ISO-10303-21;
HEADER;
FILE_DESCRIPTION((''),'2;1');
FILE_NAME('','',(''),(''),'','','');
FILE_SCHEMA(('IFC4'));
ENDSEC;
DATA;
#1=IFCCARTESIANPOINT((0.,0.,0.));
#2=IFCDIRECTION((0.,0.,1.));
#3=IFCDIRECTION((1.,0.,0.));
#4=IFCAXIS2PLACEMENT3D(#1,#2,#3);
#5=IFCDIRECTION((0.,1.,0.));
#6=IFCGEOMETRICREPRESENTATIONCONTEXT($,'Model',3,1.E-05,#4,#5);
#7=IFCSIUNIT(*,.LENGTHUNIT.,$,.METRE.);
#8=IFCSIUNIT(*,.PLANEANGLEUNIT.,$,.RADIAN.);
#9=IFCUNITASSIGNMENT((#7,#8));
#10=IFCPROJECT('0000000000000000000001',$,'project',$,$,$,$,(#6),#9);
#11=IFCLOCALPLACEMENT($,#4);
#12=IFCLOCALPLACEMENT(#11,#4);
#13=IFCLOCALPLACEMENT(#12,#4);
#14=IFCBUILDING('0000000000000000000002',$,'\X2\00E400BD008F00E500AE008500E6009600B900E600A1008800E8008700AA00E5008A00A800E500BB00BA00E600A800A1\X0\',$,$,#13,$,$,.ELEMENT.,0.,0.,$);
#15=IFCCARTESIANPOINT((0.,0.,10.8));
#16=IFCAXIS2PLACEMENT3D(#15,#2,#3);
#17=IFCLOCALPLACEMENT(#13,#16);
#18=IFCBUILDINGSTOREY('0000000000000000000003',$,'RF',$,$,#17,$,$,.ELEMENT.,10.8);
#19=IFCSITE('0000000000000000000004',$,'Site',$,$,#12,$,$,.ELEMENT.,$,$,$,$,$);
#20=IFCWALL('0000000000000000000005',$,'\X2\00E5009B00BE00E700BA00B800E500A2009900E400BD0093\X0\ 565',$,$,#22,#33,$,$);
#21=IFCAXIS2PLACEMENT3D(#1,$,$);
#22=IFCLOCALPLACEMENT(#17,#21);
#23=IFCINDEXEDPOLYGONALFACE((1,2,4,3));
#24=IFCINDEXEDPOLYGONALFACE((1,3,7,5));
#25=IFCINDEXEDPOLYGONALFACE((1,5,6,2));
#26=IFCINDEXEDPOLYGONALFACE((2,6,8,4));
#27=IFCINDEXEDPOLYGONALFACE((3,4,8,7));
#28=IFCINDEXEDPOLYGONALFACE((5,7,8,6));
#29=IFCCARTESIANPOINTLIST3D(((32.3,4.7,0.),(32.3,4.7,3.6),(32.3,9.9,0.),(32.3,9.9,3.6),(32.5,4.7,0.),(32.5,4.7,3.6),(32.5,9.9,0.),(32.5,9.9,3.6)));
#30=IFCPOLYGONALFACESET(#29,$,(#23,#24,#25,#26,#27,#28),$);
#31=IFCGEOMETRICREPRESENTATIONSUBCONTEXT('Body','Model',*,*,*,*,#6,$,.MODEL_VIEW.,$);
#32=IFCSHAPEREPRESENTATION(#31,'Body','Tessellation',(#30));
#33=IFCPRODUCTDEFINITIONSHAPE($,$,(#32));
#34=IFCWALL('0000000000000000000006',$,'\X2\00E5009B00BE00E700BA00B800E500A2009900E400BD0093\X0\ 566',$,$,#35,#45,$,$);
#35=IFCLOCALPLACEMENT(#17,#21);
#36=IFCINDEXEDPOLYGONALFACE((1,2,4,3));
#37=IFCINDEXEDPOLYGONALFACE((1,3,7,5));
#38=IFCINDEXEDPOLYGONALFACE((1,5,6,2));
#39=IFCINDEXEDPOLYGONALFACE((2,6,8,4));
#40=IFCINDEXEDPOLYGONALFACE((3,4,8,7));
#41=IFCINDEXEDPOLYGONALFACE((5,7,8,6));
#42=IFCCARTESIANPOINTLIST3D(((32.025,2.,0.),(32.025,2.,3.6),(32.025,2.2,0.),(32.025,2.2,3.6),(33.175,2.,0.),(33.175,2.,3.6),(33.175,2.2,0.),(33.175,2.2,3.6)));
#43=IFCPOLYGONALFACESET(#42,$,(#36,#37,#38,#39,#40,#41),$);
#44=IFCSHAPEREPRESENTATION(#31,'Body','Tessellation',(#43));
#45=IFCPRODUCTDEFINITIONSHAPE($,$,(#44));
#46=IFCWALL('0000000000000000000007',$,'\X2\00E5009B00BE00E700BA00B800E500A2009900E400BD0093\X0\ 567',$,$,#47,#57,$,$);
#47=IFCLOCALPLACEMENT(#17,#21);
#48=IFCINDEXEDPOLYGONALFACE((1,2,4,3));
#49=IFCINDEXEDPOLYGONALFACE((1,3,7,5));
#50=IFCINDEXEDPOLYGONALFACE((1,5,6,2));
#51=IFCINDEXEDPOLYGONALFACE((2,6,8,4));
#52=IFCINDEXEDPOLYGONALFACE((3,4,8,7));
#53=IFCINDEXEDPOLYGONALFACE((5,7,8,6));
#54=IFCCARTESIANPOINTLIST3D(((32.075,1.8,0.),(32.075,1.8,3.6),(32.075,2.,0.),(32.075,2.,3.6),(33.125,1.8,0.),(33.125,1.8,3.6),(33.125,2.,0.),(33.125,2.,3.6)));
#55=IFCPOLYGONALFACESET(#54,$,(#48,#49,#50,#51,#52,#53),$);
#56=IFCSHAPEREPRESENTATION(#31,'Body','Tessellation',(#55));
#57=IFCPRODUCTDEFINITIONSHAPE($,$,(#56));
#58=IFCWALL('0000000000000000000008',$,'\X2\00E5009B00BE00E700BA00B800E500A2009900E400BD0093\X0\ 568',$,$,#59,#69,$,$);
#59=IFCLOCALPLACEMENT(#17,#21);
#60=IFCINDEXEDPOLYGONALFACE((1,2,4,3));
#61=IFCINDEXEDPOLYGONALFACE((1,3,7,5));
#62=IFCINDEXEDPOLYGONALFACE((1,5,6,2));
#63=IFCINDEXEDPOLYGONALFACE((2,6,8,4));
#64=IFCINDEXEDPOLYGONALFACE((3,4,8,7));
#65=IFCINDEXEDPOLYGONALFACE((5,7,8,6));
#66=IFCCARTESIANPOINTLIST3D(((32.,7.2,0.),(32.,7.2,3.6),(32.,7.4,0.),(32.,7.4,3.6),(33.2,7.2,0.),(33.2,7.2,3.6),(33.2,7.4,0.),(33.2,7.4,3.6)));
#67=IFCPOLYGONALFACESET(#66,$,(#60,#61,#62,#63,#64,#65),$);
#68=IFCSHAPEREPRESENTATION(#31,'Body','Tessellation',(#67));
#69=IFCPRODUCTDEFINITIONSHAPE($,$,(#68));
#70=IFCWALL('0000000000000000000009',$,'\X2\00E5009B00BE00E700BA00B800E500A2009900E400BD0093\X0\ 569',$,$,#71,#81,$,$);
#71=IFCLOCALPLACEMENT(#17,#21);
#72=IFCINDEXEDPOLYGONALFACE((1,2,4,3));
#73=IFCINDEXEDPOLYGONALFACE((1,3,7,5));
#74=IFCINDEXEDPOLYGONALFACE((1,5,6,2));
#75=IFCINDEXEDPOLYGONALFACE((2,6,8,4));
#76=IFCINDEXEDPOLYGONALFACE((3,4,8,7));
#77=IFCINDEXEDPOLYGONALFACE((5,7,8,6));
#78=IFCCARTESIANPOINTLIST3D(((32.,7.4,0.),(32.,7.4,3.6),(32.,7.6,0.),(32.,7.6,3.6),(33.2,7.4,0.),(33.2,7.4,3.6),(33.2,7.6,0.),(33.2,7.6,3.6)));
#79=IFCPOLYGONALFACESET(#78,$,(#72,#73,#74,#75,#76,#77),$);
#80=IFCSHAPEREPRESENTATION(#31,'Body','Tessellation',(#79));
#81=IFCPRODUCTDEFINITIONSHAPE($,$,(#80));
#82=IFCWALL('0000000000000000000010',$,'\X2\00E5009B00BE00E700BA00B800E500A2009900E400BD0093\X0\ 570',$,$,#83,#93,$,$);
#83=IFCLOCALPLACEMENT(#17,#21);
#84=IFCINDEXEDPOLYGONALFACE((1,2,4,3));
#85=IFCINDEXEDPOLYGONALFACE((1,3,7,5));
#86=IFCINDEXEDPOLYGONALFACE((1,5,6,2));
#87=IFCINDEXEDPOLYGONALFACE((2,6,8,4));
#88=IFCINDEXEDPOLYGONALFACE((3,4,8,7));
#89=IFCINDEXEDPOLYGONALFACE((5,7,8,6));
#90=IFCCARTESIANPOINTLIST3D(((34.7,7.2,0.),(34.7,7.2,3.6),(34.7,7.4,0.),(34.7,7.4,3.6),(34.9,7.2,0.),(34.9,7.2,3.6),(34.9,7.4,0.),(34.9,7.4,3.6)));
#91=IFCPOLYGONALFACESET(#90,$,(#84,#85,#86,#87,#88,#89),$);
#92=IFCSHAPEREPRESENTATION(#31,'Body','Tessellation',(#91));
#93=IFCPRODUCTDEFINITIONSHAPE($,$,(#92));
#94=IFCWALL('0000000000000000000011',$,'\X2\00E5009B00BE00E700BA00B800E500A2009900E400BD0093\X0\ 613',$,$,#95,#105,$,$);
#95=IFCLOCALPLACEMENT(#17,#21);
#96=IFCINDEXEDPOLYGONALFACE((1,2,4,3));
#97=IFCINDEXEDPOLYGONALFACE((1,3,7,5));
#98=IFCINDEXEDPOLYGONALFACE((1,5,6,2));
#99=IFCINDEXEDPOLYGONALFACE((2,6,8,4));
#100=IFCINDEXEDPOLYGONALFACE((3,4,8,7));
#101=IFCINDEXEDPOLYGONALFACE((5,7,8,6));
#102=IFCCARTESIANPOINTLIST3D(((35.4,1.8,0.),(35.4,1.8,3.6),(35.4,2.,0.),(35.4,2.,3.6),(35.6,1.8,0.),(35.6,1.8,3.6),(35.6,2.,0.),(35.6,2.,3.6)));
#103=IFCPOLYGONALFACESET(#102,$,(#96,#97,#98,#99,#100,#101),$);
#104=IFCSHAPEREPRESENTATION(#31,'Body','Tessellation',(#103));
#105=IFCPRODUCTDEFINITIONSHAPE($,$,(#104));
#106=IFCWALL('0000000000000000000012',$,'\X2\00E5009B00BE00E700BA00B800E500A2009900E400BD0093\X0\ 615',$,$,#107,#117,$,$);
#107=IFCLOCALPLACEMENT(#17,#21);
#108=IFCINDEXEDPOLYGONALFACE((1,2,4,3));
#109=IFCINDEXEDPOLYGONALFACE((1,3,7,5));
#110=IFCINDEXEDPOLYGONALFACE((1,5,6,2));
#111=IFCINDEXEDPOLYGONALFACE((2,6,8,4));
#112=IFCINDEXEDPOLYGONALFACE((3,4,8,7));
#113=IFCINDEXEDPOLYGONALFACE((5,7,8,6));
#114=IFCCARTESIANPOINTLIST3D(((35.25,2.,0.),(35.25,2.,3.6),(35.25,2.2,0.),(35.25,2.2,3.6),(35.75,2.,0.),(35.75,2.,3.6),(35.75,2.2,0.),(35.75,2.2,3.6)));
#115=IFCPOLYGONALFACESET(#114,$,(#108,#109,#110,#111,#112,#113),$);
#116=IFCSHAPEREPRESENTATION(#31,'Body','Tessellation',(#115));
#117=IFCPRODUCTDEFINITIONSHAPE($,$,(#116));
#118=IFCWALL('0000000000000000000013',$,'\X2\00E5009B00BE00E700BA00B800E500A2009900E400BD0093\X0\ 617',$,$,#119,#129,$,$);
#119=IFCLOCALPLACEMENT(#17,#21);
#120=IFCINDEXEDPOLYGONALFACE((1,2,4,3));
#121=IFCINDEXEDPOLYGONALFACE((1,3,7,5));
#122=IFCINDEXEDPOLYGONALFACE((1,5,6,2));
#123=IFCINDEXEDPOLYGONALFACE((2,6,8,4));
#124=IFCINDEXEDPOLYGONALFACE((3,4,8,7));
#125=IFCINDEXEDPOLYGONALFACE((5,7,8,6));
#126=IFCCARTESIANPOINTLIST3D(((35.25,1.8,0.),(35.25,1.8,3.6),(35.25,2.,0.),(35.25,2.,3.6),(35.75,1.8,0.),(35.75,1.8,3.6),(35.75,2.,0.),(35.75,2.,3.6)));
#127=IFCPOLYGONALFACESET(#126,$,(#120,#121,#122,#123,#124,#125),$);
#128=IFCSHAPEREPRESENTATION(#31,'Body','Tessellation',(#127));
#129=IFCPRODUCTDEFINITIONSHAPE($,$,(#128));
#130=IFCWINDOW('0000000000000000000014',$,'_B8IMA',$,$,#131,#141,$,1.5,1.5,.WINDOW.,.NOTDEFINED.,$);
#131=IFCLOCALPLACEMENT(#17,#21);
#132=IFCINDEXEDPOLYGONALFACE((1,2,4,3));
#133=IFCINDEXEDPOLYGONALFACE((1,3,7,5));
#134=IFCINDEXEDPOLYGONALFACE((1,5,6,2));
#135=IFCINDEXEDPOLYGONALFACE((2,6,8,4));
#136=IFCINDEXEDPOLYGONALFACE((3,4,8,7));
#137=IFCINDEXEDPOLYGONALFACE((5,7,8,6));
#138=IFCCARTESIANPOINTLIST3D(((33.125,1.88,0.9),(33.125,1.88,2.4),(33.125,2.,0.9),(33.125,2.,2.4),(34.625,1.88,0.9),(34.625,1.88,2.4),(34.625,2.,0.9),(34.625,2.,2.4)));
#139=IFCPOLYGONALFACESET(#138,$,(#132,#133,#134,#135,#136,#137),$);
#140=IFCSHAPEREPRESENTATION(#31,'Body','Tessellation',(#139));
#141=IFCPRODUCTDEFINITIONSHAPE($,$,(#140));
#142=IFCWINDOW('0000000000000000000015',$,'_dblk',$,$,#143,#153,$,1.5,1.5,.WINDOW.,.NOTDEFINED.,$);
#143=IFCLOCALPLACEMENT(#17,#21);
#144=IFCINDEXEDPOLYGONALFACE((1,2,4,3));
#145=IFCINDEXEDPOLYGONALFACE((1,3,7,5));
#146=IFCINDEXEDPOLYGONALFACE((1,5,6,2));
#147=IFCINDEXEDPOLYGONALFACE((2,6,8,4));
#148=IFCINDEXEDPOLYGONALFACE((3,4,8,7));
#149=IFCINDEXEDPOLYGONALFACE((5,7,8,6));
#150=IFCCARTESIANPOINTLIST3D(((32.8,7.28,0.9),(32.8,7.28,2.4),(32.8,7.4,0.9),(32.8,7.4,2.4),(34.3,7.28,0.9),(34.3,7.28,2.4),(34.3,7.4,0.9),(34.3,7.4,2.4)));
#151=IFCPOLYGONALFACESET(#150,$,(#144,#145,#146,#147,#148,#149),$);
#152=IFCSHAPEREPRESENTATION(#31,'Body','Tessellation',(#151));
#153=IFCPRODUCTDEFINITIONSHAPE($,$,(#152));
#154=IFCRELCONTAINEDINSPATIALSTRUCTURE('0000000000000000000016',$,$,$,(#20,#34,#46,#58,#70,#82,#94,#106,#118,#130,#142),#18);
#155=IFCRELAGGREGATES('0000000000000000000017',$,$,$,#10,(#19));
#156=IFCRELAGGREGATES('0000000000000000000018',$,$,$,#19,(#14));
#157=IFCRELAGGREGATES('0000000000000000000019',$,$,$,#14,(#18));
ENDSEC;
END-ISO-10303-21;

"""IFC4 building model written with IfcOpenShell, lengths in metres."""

from ifc_helpers import new_model, si_unit, direction, frame, frame_2d, origin_with_axes, place, context, subcontext, project, spatial, rectangle, extrude, element, save


model = new_model("IFC4")

# Units and contexts
model_context = context("Model", 3, precision=1e-05, world=origin_with_axes(), true_north=direction((0.0, 1.0, 0.0)))
body_context = subcontext(model_context, "Body", "Model", "MODEL_VIEW")
ifc_project = project(units=[si_unit("LENGTHUNIT", "METRE"), si_unit("PLANEANGLEUNIT", "RADIAN")], contexts=[model_context])

# Site, building, storey
placement = place(None, origin_with_axes())
site_placement = place(placement, origin_with_axes())
site = spatial("IfcSite", under=ifc_project, at=site_placement, Name="Site", CompositionType="ELEMENT")
building_placement = place(site_placement, origin_with_axes())
building = spatial("IfcBuilding", under=site, at=building_placement, Name="ä½\u008få®\u0085æ\u0096¹æ¡\u0088è\u0087ªå\u008a¨å»ºæ¨¡", CompositionType="ELEMENT", ElevationOfRefHeight=0.0, ElevationOfTerrain=0.0)
storey_placement = place(building_placement, frame((0.0, 0.0, 10.8), z_axis=(0.0, 0.0, 1.0), x_axis=(1.0, 0.0, 0.0)))
storey = spatial("IfcBuildingStorey", under=building, at=storey_placement, Name="RF", CompositionType="ELEMENT", Elevation=10.8)

# Walls
for number, where, z_axis, x_axis, name in (
    (1, (32.4, 7.3, 0.0), (0.0, 0.0, 1.0), (0.0, -1.0, 0.0), "å\u009b¾çº¸å¢\u0099ä½\u0093 565"),
):
    element("IfcWall", number, at=place(storey_placement, frame(where, z_axis=z_axis, x_axis=x_axis)), inside=storey, Name=name, context=body_context, shape_type="SweptSolid", body=[
        extrude(rectangle(XDim=5.2, YDim=0.2, at=frame_2d((0.0, 0.0), x_axis=(1.0, 0.0, 0.0))), frame((0.0, 0.0, 0.0), z_axis=(0.0, 0.0, 1.0)), (0.0, 0.0, 1.0), 3.6),
    ])
wall_1_placement = place(storey_placement, frame((32.6, 2.1, 0.0), z_axis=(0.0, 0.0, 1.0), x_axis=(1.0, 0.0, 0.0)))
element("IfcWall", 2, at=wall_1_placement, inside=storey, Name="å\u009b¾çº¸å¢\u0099ä½\u0093 566", context=body_context, shape_type="SweptSolid", body=[
    extrude(rectangle(XDim=1.15, YDim=0.2, at=frame_2d((0.0, 0.0), x_axis=(1.0, 0.0, 0.0))), frame((0.0, 0.0, 0.0), z_axis=(0.0, 0.0, 1.0)), (0.0, 0.0, 1.0), 3.6),
])
wall_2_placement = place(storey_placement, frame((32.6, 1.9, 0.0), z_axis=(0.0, 0.0, 1.0), x_axis=(1.0, 0.0, 0.0)))
element("IfcWall", 3, at=wall_2_placement, inside=storey, Name="å\u009b¾çº¸å¢\u0099ä½\u0093 567", context=body_context, shape_type="SweptSolid", body=[
    extrude(rectangle(XDim=1.05, YDim=0.2, at=frame_2d((0.0, 0.0), x_axis=(1.0, 0.0, 0.0))), frame((0.0, 0.0, 0.0), z_axis=(0.0, 0.0, 1.0)), (0.0, 0.0, 1.0), 3.6),
])
for number, where, z_axis, x_axis, name in (
    (4, (32.6, 7.3, 0.0), (0.0, 0.0, 1.0), (1.0, 0.0, 0.0), "å\u009b¾çº¸å¢\u0099ä½\u0093 568"),
    (5, (32.6, 7.5, 0.0), (0.0, 0.0, 1.0), (1.0, 0.0, 0.0), "å\u009b¾çº¸å¢\u0099ä½\u0093 569"),
):
    element("IfcWall", number, at=place(storey_placement, frame(where, z_axis=z_axis, x_axis=x_axis)), inside=storey, Name=name, context=body_context, shape_type="SweptSolid", body=[
        extrude(rectangle(XDim=1.2, YDim=0.2, at=frame_2d((0.0, 0.0), x_axis=(1.0, 0.0, 0.0))), frame((0.0, 0.0, 0.0), z_axis=(0.0, 0.0, 1.0)), (0.0, 0.0, 1.0), 3.6),
    ])
for number, where, z_axis, x_axis, name in (
    (6, (34.8, 7.3, 0.0), (0.0, 0.0, 1.0), (0.0, 1.0, 0.0), "å\u009b¾çº¸å¢\u0099ä½\u0093 570"),
    (7, (35.5, 1.9, 0.0), (0.0, 0.0, 1.0), (0.0, 1.0, 0.0), "å\u009b¾çº¸å¢\u0099ä½\u0093 613"),
):
    element("IfcWall", number, at=place(storey_placement, frame(where, z_axis=z_axis, x_axis=x_axis)), inside=storey, Name=name, context=body_context, shape_type="SweptSolid", body=[
        extrude(rectangle(XDim=0.2, YDim=0.2, at=frame_2d((0.0, 0.0), x_axis=(1.0, 0.0, 0.0))), frame((0.0, 0.0, 0.0), z_axis=(0.0, 0.0, 1.0)), (0.0, 0.0, 1.0), 3.6),
    ])
for number, where, z_axis, x_axis, name in (
    (8, (35.5, 2.1, 0.0), (0.0, 0.0, 1.0), (1.0, 0.0, 0.0), "å\u009b¾çº¸å¢\u0099ä½\u0093 615"),
    (9, (35.5, 1.9, 0.0), (0.0, 0.0, 1.0), (1.0, 0.0, 0.0), "å\u009b¾çº¸å¢\u0099ä½\u0093 617"),
):
    element("IfcWall", number, at=place(storey_placement, frame(where, z_axis=z_axis, x_axis=x_axis)), inside=storey, Name=name, context=body_context, shape_type="SweptSolid", body=[
        extrude(rectangle(XDim=0.5, YDim=0.2, at=frame_2d((0.0, 0.0), x_axis=(1.0, 0.0, 0.0))), frame((0.0, 0.0, 0.0), z_axis=(0.0, 0.0, 1.0)), (0.0, 0.0, 1.0), 3.6),
    ])

# Windows
for number, where, z_axis, x_axis, name in (
    (10, (33.875, 1.94, 0.9), (0.0, 0.0, 1.0), (1.0, 0.0, 0.0), "_B8IMA"),
    (11, (33.55, 7.34, 0.9), (0.0, 0.0, 1.0), (1.0, 0.0, 0.0), "_dblk"),
):
    element("IfcWindow", number, at=place(storey_placement, frame(where, z_axis=z_axis, x_axis=x_axis)), inside=storey, Name=name, OverallHeight=1.5, OverallWidth=1.5, PartitioningType="NOTDEFINED", PredefinedType="WINDOW", context=body_context, shape_type="SweptSolid", body=[
        extrude(rectangle(XDim=1.5, YDim=0.12, at=frame_2d((0.0, 0.0), x_axis=(1.0, 0.0, 0.0))), frame((0.0, 0.0, 0.0), z_axis=(0.0, 0.0, 1.0)), (0.0, 0.0, 1.0), 1.5),
    ])

save(model, "model.ifc")
